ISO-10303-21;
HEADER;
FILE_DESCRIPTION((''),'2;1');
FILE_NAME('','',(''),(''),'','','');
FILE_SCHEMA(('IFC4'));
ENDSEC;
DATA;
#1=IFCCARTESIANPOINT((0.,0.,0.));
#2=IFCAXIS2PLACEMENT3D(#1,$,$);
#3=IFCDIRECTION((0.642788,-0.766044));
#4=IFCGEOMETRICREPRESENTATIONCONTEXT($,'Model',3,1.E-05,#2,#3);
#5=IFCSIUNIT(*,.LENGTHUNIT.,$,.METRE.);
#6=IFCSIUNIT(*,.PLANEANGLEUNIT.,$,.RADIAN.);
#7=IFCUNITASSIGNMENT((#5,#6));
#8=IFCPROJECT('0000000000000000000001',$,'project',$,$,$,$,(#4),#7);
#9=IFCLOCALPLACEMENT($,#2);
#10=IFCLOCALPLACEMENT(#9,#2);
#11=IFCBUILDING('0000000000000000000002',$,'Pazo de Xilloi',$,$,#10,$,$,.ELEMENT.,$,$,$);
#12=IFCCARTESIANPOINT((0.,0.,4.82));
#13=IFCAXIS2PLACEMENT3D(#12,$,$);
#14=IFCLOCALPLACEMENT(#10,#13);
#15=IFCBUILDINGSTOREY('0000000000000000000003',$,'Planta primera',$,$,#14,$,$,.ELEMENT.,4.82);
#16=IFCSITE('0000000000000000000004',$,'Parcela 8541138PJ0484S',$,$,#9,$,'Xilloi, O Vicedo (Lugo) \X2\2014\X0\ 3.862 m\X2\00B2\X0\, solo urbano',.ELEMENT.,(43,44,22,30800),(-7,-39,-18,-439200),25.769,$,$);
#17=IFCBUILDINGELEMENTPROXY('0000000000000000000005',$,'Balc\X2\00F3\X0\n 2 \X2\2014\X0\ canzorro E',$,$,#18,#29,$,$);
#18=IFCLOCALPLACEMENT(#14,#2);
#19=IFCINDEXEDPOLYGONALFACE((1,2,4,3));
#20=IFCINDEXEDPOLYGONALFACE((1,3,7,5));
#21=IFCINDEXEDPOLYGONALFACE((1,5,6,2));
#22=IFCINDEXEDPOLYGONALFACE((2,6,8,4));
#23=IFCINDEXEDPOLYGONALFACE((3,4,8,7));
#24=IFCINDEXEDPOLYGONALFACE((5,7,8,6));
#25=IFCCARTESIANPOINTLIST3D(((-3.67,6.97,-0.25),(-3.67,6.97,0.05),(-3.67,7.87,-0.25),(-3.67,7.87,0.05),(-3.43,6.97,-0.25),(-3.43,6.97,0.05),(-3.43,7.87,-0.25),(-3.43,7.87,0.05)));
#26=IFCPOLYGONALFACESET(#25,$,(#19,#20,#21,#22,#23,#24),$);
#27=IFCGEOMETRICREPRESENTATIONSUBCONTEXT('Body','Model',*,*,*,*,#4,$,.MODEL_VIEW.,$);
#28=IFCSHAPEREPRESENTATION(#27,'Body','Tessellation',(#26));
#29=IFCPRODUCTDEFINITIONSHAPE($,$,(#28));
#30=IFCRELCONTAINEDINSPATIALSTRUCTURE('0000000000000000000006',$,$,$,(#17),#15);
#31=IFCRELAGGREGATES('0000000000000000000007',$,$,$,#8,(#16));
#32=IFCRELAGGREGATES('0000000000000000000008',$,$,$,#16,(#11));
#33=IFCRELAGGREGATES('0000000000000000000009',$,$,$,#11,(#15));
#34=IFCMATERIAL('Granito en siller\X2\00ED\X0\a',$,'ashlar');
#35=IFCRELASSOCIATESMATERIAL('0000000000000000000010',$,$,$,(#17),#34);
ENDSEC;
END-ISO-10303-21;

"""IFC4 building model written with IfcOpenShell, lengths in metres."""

from ifc_helpers import new_model, si_unit, direction, frame, origin, origin_2d, place, context, subcontext, project, spatial, rectangle, extrude, material, element, save


model = new_model("IFC4")

# Units and contexts
model_context = context("Model", 3, precision=1e-05, world=origin(), true_north=direction((0.642788, -0.766044)))
body_context = subcontext(model_context, "Body", "Model", "MODEL_VIEW")
ifc_project = project(units=[si_unit("LENGTHUNIT", "METRE"), si_unit("PLANEANGLEUNIT", "RADIAN")], contexts=[model_context])

# Site, building, storey
site_placement = place(None, origin())
site = spatial("IfcSite", under=ifc_project, at=site_placement, Name="Parcela 8541138PJ0484S", LongName="Xilloi, O Vicedo (Lugo) — 3.862 m², solo urbano", CompositionType="ELEMENT", RefLatitude=(43, 44, 22, 30800), RefLongitude=(-7, -39, -18, -439200), RefElevation=25.769)
building_placement = place(site_placement, origin())
building = spatial("IfcBuilding", under=site, at=building_placement, Name="Pazo de Xilloi", CompositionType="ELEMENT")
storey_placement = place(building_placement, frame((0.0, 0.0, 4.82)))
storey = spatial("IfcBuildingStorey", under=building, at=storey_placement, Name="Planta primera", CompositionType="ELEMENT", Elevation=4.82)

# Shared definitions
ifc_material_1 = material(Name="Granito en sillería", Category="ashlar")

# Building element proxy
for number, where, name in (
    (1, (-3.55, 7.42, -0.1), "Balcón 2 — canzorro E"),
):
    element("IfcBuildingElementProxy", number, at=place(storey_placement, frame(where)), inside=storey, material=ifc_material_1, Name=name, context=body_context, shape_type="SweptSolid", body=[
        extrude(rectangle(XDim=0.24, YDim=0.9, at=origin_2d()), frame((0.0, 0.0, -0.15)), (0.0, 0.0, 1.0), 0.3),
    ])

save(model, "model.ifc")
